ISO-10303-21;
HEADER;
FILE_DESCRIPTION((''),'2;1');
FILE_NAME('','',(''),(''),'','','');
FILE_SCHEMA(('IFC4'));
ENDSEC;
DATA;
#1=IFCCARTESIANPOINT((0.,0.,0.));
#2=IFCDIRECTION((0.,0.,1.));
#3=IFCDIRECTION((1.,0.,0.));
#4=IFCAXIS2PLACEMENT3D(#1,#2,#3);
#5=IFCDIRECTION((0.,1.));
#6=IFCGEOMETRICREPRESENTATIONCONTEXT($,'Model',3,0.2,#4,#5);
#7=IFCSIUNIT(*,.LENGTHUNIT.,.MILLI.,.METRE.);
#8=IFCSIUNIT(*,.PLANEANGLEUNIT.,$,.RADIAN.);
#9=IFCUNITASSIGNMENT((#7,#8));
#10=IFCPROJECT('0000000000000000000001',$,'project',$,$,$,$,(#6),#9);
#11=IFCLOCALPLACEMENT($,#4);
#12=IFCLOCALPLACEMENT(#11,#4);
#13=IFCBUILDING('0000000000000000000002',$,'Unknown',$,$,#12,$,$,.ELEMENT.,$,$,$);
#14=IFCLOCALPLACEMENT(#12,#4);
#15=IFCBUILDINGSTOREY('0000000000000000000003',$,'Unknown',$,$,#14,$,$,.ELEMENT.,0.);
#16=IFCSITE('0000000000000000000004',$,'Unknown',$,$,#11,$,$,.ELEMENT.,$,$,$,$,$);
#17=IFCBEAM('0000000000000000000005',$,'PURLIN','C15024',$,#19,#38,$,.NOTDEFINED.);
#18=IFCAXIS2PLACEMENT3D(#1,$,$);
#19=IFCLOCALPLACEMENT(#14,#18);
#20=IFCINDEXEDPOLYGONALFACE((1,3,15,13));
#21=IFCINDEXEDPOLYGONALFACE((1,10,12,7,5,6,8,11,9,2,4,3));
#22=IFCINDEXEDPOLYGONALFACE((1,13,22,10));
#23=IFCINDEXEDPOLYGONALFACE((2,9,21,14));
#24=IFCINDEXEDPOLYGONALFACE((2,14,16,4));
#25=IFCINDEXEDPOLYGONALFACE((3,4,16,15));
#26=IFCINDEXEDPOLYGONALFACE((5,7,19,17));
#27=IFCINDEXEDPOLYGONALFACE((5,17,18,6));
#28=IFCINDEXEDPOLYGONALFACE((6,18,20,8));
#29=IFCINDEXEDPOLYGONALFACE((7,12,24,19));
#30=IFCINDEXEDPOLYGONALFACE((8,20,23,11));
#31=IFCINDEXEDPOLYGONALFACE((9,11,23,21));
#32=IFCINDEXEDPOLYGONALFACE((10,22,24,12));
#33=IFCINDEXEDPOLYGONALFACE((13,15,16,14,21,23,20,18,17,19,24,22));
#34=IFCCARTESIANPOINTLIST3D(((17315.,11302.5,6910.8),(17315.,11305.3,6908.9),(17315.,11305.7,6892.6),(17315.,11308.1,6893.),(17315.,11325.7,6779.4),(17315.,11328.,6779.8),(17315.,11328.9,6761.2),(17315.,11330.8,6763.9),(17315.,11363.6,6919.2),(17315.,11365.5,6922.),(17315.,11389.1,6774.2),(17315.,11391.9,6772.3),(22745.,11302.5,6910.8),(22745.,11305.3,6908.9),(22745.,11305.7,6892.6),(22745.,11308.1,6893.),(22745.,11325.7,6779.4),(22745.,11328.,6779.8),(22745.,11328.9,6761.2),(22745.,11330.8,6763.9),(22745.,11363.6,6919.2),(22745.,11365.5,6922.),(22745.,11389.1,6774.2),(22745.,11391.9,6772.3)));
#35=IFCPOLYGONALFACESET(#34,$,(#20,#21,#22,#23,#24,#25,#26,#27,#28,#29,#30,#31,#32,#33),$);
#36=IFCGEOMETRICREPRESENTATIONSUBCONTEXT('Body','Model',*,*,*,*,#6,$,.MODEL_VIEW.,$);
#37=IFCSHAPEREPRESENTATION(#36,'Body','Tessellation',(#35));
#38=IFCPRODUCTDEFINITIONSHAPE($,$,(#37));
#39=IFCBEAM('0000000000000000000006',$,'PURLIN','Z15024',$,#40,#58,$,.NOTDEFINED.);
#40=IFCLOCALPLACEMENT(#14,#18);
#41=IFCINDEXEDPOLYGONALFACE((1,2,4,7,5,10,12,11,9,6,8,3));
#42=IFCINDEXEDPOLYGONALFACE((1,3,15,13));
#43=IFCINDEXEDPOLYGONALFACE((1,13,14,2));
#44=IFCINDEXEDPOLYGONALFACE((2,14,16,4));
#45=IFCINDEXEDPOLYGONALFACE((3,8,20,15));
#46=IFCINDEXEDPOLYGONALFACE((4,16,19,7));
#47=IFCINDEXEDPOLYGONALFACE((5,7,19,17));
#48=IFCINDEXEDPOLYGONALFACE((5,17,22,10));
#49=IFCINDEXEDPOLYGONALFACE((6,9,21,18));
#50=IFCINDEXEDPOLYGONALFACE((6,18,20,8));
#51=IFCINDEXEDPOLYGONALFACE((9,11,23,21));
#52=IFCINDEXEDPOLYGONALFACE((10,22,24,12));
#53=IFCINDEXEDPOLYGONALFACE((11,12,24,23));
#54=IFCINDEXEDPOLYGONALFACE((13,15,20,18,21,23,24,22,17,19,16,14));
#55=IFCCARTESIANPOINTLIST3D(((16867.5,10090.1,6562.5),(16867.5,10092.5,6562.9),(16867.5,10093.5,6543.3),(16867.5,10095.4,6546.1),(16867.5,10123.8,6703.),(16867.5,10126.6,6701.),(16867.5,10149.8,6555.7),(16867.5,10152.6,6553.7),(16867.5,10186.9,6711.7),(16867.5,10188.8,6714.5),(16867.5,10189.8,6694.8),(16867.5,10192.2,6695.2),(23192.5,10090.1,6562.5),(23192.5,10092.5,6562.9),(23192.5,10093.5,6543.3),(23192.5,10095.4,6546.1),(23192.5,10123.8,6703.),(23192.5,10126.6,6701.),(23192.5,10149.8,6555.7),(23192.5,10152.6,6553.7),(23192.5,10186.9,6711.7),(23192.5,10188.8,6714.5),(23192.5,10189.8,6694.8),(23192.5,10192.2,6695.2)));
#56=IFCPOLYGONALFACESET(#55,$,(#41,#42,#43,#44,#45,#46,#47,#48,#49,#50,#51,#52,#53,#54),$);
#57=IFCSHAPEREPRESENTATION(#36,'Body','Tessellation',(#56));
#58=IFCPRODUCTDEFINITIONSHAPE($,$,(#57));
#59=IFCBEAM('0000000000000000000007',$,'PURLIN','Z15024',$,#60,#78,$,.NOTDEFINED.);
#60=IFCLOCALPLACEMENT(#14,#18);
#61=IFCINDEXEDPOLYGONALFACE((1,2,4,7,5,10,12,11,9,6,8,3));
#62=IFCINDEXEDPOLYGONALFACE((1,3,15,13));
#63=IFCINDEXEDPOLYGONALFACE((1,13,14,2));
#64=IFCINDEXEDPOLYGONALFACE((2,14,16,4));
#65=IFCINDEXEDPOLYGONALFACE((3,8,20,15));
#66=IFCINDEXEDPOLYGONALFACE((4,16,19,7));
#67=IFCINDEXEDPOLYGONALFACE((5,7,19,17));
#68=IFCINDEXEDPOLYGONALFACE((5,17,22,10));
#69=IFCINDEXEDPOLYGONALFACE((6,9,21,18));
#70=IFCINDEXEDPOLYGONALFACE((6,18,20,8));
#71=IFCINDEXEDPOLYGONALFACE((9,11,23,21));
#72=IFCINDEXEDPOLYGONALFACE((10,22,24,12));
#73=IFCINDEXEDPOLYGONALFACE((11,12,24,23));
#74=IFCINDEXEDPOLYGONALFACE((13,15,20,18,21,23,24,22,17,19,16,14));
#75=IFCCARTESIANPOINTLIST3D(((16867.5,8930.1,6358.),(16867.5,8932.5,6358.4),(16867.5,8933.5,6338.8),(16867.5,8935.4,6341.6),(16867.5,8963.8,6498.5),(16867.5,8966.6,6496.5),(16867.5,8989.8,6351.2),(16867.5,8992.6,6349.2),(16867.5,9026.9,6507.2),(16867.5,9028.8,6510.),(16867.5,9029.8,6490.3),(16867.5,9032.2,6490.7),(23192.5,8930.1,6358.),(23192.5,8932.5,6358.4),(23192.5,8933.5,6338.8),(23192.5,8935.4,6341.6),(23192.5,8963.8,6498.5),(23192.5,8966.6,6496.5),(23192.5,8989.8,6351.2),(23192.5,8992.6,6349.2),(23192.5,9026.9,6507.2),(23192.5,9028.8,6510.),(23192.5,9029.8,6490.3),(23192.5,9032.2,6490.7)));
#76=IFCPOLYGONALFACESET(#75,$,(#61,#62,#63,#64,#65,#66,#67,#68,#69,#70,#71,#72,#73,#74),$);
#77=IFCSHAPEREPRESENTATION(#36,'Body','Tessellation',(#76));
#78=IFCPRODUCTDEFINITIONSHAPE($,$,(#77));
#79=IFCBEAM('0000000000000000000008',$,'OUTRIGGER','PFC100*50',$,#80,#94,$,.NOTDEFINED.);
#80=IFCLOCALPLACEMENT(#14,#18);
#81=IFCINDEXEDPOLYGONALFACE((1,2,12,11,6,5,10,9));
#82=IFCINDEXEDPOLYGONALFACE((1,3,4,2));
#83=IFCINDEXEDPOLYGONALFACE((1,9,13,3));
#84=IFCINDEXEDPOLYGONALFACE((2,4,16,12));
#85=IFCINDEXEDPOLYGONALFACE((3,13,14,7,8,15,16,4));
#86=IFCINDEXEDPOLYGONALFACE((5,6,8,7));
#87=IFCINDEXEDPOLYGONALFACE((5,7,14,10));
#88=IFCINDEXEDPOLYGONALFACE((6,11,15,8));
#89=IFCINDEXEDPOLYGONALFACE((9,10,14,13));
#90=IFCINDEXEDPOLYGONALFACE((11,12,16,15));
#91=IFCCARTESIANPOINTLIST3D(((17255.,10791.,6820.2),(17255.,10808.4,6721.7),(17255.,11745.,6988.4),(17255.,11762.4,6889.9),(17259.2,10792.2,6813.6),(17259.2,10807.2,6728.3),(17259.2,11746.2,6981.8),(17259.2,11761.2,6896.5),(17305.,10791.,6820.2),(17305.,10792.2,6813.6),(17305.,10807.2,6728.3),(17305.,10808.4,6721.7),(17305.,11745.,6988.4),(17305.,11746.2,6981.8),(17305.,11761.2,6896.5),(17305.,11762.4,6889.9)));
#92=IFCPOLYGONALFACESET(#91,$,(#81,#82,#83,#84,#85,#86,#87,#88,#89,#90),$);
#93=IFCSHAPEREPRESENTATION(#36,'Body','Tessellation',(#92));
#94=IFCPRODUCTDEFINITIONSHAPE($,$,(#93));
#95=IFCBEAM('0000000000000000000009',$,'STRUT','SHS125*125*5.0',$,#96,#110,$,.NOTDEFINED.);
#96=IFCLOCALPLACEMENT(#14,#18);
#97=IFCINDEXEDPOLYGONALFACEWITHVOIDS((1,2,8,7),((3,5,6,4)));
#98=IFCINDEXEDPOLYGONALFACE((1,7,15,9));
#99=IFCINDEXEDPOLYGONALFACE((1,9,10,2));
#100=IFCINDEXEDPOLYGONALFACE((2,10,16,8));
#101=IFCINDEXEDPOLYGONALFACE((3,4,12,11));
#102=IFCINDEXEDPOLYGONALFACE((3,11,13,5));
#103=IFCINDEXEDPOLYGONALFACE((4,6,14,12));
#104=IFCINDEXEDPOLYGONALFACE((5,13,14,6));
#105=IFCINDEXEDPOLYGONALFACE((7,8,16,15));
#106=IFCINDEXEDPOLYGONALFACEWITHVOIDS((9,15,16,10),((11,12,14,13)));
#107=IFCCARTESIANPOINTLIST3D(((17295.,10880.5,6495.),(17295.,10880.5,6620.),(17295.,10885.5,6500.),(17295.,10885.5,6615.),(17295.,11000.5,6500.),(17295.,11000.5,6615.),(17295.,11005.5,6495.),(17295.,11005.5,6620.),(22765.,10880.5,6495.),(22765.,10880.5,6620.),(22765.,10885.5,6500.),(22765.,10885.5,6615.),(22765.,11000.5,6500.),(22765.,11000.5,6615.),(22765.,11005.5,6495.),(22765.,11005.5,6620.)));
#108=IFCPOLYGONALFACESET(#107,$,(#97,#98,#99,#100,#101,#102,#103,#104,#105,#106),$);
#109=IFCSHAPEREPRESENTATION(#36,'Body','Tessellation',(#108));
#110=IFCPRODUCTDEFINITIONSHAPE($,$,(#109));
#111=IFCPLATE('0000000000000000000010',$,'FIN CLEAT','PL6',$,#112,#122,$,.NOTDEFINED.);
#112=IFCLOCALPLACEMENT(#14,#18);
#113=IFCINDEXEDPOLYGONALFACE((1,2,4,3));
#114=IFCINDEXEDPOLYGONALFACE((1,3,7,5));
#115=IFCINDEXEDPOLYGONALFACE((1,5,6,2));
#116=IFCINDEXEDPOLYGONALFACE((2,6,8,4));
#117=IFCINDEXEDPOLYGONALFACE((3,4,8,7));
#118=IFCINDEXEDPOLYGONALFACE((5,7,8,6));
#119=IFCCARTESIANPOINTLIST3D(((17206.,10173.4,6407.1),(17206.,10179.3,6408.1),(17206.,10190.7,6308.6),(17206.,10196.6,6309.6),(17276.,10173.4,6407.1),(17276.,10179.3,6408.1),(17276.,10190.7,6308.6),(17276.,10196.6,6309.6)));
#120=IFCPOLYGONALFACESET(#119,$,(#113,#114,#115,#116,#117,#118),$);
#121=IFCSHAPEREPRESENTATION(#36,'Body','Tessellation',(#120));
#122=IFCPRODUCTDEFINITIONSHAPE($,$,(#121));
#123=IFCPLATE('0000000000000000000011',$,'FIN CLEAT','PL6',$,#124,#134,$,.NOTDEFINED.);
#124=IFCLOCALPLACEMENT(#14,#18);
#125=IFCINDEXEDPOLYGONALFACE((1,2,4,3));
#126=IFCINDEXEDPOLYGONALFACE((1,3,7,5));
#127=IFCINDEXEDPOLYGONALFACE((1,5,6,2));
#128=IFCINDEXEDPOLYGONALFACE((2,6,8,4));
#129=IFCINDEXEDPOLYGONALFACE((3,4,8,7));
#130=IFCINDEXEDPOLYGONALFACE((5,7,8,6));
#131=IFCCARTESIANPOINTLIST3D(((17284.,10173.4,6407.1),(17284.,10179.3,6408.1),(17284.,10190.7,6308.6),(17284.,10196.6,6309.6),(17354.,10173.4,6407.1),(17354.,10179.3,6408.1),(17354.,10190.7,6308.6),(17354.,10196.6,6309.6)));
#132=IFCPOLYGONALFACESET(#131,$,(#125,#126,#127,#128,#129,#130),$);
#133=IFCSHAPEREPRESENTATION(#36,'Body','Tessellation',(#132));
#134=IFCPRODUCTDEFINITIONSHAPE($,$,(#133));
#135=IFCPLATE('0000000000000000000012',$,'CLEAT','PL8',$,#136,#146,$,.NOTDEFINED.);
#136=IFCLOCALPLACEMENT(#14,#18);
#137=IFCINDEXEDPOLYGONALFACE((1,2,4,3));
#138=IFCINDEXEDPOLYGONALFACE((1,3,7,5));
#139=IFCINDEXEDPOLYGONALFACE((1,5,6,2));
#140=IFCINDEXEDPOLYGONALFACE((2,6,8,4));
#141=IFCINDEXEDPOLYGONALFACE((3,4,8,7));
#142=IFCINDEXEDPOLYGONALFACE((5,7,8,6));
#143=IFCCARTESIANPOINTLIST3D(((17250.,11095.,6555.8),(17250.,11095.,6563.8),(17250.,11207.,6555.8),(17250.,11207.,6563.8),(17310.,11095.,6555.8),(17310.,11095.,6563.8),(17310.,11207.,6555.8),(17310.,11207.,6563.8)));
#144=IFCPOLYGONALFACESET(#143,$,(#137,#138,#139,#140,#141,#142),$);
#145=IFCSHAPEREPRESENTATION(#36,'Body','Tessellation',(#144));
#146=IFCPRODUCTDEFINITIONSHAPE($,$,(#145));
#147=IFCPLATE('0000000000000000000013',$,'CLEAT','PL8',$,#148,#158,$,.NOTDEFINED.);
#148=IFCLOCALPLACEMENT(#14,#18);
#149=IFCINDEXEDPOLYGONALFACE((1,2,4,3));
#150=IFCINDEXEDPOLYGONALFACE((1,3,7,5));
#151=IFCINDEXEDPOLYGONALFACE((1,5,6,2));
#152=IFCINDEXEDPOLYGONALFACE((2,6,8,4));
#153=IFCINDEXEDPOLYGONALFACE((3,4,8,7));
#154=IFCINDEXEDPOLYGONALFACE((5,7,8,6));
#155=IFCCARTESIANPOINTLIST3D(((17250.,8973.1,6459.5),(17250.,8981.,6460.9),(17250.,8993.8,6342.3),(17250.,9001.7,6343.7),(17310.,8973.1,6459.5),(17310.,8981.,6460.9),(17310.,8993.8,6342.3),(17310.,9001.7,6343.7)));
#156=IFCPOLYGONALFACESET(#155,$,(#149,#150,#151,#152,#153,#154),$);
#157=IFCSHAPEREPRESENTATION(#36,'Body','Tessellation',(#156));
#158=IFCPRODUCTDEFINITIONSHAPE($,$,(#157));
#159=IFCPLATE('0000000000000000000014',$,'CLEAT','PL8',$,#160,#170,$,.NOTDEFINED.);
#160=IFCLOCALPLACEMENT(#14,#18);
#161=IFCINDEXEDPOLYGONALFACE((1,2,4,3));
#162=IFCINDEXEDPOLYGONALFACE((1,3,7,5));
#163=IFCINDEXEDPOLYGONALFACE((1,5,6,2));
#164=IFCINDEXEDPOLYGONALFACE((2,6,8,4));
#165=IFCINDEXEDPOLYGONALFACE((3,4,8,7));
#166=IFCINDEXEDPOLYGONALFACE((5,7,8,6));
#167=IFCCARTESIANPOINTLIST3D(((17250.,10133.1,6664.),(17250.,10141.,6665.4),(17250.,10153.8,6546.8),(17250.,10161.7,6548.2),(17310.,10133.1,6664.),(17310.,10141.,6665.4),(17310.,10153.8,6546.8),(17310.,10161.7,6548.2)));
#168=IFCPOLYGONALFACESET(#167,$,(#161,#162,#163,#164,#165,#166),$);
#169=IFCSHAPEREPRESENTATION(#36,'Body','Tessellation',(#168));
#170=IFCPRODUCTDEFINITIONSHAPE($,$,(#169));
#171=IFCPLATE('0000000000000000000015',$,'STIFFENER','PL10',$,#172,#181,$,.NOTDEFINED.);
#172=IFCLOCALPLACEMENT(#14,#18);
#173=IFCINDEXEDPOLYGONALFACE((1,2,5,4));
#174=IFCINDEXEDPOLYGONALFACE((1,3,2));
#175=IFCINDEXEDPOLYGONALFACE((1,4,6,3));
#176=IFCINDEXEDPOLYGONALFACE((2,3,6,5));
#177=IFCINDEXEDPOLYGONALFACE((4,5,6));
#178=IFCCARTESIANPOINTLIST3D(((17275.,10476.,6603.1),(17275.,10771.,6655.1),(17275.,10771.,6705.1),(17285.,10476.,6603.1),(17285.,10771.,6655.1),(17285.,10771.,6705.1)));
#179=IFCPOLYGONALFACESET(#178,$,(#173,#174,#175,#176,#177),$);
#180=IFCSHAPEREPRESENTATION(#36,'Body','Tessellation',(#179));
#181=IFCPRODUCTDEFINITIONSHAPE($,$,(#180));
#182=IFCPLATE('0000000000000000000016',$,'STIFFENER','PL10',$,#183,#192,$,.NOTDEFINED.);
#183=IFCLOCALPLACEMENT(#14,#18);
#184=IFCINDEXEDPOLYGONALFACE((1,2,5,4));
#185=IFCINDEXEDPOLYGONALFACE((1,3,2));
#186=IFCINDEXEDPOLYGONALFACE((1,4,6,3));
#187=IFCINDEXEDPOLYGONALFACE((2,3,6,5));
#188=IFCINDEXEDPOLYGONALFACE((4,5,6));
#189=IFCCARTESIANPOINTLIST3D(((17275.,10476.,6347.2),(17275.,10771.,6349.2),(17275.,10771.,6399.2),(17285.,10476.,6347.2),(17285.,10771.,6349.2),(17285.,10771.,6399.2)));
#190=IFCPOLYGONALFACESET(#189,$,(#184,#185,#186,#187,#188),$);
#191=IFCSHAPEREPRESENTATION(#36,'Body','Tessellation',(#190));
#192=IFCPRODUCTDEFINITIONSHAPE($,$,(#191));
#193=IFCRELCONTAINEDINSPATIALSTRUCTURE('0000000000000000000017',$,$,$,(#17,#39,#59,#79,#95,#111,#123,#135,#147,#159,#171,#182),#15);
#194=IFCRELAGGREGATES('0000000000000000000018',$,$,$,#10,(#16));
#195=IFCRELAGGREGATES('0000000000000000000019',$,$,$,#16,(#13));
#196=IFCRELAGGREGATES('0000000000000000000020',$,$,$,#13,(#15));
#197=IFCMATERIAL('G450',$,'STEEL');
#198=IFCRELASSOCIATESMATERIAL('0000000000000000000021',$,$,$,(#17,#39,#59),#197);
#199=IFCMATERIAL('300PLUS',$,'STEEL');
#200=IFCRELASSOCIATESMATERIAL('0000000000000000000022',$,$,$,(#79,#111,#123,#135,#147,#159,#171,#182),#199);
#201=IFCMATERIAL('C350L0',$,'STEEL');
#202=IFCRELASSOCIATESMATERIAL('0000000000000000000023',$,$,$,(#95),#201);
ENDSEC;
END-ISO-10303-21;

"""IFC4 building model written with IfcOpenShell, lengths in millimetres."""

from ifc_helpers import new_model, si_unit, direction, frame, origin_with_axes, place, context, subcontext, project, spatial, line, indexed_curve, outline, extrude, material, element, save


model = new_model("IFC4")

# Units and contexts
model_context = context("Model", 3, precision=0.2, world=origin_with_axes(), true_north=direction((0.0, 1.0)))
body_context = subcontext(model_context, "Body", "Model", "MODEL_VIEW")
ifc_project = project(units=[si_unit("LENGTHUNIT", "METRE", prefix="MILLI"), si_unit("PLANEANGLEUNIT", "RADIAN")], contexts=[model_context])

# Site, building, storey
site_placement = place(None, origin_with_axes())
site = spatial("IfcSite", under=ifc_project, at=site_placement, Name="Unknown", CompositionType="ELEMENT")
building_placement = place(site_placement, origin_with_axes())
building = spatial("IfcBuilding", under=site, at=building_placement, Name="Unknown", CompositionType="ELEMENT")
storey_placement = place(building_placement, origin_with_axes())
storey = spatial("IfcBuildingStorey", under=building, at=storey_placement, Name="Unknown", CompositionType="ELEMENT", Elevation=0.0)

# Shared definitions
ifc_material_1 = material(Name="300PLUS", Category="STEEL")

# Beams
ifc_material_2 = material(Name="G450", Category="STEEL")
beam_1_placement = place(storey_placement, frame((17315.0, 11347.2, 6841.6), z_axis=(0.0, -0.984808, -0.173648), x_axis=(1.0, 0.0, 0.0)))
element("IfcBeam", 1, at=beam_1_placement, inside=storey, material=ifc_material_2, Name="PURLIN", Description="C15024", PredefinedType="NOTDEFINED", context=body_context, shape_type="SolidModel", body=[
    extrude(outline(indexed_curve([(32.0, -76.0), (32.0, -57.5), (29.6, -57.5), (29.6, -73.6), (-29.6, -73.6), (-29.6, 73.6), (29.6, 73.6), (29.6, 57.5), (32.0, 57.5), (32.0, 76.0), (-32.0, 76.0), (-32.0, -76.0)], segments=[line(1, 2, 3, 4, 5, 6, 7, 8, 9, 10, 11, 12, 1)])), frame((0.0, 0.0, 0.0), z_axis=(-1.0, 0.0, 0.0), x_axis=(0.0, 0.0, 1.0)), (0.0, 0.0, -1.0), 5430.0),
])
for number, where, z_axis, x_axis, name in (
    (2, (16867.5, 10138.2, 6628.4), (0.0, -0.984808, -0.173648), (1.0, 0.0, 0.0), "PURLIN"),
    (3, (16867.5, 8978.2, 6423.9), (0.0, -0.984808, -0.173648), (1.0, 0.0, 0.0), "PURLIN"),
):
    element("IfcBeam", number, at=place(storey_placement, frame(where, z_axis=z_axis, x_axis=x_axis)), inside=storey, material=ifc_material_2, Name=name, Description="Z15024", PredefinedType="NOTDEFINED", context=body_context, shape_type="SolidModel", body=[
        extrude(outline(indexed_curve([(58.8, -76.0), (58.8, -56.5), (56.4, -56.5), (56.4, -73.6), (1.2, -73.6), (1.2, 76.0), (-64.8, 76.0), (-64.8, 56.5), (-62.4, 56.5), (-62.4, 73.6), (-1.2, 73.6), (-1.2, -76.0)], segments=[line(1, 2, 3, 4, 5, 6, 7, 8, 9, 10, 11, 12, 1)])), frame((0.0, 0.0, 0.0), z_axis=(-1.0, 0.0, 0.0), x_axis=(0.0, 0.0, 1.0)), (0.0, 0.0, -1.0), 6325.0),
    ])
beam_2_placement = place(storey_placement, frame((17280.0, 10799.7, 6771.0), z_axis=(1.0, 0.0, 0.0), x_axis=(0.0, 0.984811, 0.173632)))
element("IfcBeam", 4, at=beam_2_placement, inside=storey, material=ifc_material_1, Name="OUTRIGGER", Description="PFC100*50", PredefinedType="NOTDEFINED", context=body_context, shape_type="SolidModel", body=[
    extrude(outline(indexed_curve([(-25.0, -50.0), (25.0, -50.0), (25.0, -43.3), (-20.8, -43.3), (-20.8, 43.3), (25.0, 43.3), (25.0, 50.0), (-25.0, 50.0)], segments=[line(1, 2, 3, 4, 5, 6, 7, 8, 1)])), frame((0.0, 0.0, 0.0), z_axis=(-1.0, 0.0, 0.0), x_axis=(0.0, 0.0, 1.0)), (0.0, 0.0, -1.0), 968.7),
])
ifc_material_3 = material(Name="C350L0", Category="STEEL")
beam_3_placement = place(storey_placement, frame((17295.0, 10943.0, 6557.5), z_axis=(0.0, 0.0, 1.0), x_axis=(1.0, 0.0, 0.0)))
element("IfcBeam", 5, at=beam_3_placement, inside=storey, material=ifc_material_3, Name="STRUT", Description="SHS125*125*5.0", PredefinedType="NOTDEFINED", context=body_context, shape_type="SolidModel", body=[
    extrude(outline(indexed_curve([(-62.5, -62.5), (62.5, -62.5), (62.5, 62.5), (-62.5, 62.5)], segments=[line(1, 2, 3, 4, 1)]), holes=[indexed_curve([(-57.5, -57.5), (-57.5, 57.5), (57.5, 57.5), (57.5, -57.5)], segments=[line(1, 2, 3, 4, 1)])]), frame((0.0, 0.0, 0.0), z_axis=(-1.0, 0.0, 0.0), x_axis=(0.0, 0.0, 1.0)), (0.0, 0.0, -1.0), 5470.0),
])

# Plates
for number, where, z_axis, x_axis, name in (
    (6, (17206.0, 10176.4, 6407.6), (0.0, 0.984924, 0.172987), (1.0, 0.0, 0.0), "FIN CLEAT"),
    (7, (17284.0, 10176.4, 6407.6), (0.0, 0.984924, 0.172987), (1.0, 0.0, 0.0), "FIN CLEAT"),
):
    element("IfcPlate", number, at=place(storey_placement, frame(where, z_axis=z_axis, x_axis=x_axis)), inside=storey, material=ifc_material_1, Name=name, Description="PL6", PredefinedType="NOTDEFINED", context=body_context, shape_type="SolidModel", body=[
        extrude(outline(indexed_curve([(0.0, 0.0), (70.0, 0.0), (70.0, 100.0), (0.0, 100.0)], segments=[line(1, 2, 3, 4, 1)])), frame((0.0, 0.0, 3.0), z_axis=(0.0, 0.0, 1.0), x_axis=(1.0, 0.0, 0.0)), (0.0, 0.0, -1.0), 6.0),
    ])
plate_1_placement = place(storey_placement, frame((17250.0, 11095.0, 6559.8), z_axis=(0.0, 0.0, 1.0), x_axis=(1.0, 0.0, 0.0)))
element("IfcPlate", 8, at=plate_1_placement, inside=storey, material=ifc_material_1, Name="CLEAT", Description="PL8", PredefinedType="NOTDEFINED", context=body_context, shape_type="SolidModel", body=[
    extrude(outline(indexed_curve([(0.0, 0.0), (60.0, 0.0), (60.0, 112.0), (0.0, 112.0)], segments=[line(1, 2, 3, 4, 1)])), frame((0.0, 0.0, 4.0), z_axis=(0.0, 0.0, 1.0), x_axis=(1.0, 0.0, 0.0)), (0.0, 0.0, -1.0), 8.0),
])
for number, where, z_axis, x_axis, name in (
    (9, (17310.0, 8997.7, 6343.0), (0.0, 0.984758, 0.173929), (-1.0, 0.0, 0.0), "CLEAT"),
    (10, (17310.0, 10157.7, 6547.5), (0.0, 0.984758, 0.173929), (-1.0, 0.0, 0.0), "CLEAT"),
):
    element("IfcPlate", number, at=place(storey_placement, frame(where, z_axis=z_axis, x_axis=x_axis)), inside=storey, material=ifc_material_1, Name=name, Description="PL8", PredefinedType="NOTDEFINED", context=body_context, shape_type="SolidModel", body=[
        extrude(outline(indexed_curve([(0.0, 0.0), (60.0, 0.0), (60.0, 119.0), (0.0, 119.0)], segments=[line(1, 2, 3, 4, 1)])), frame((0.0, 0.0, 4.0), z_axis=(0.0, 0.0, 1.0), x_axis=(1.0, 0.0, 0.0)), (0.0, 0.0, -1.0), 8.0),
    ])
plate_2_placement = place(storey_placement, frame((17280.0, 10771.0, 6655.1), z_axis=(1.0, 0.0, 0.0), x_axis=(0.0, 0.0, 1.0)))
element("IfcPlate", 11, at=plate_2_placement, inside=storey, material=ifc_material_1, Name="STIFFENER", Description="PL10", PredefinedType="NOTDEFINED", context=body_context, shape_type="SolidModel", body=[
    extrude(outline(indexed_curve([(0.0, 0.0), (50.0, 0.0), (-52.0, 295.0)], segments=[line(1, 2, 3, 1)])), frame((0.0, 0.0, 5.0), z_axis=(0.0, 0.0, 1.0), x_axis=(1.0, 0.0, 0.0)), (0.0, 0.0, -1.0), 10.0),
])
plate_3_placement = place(storey_placement, frame((17280.0, 10771.0, 6349.2), z_axis=(1.0, 0.0, 0.0), x_axis=(0.0, 0.0, 1.0)))
element("IfcPlate", 12, at=plate_3_placement, inside=storey, material=ifc_material_1, Name="STIFFENER", Description="PL10", PredefinedType="NOTDEFINED", context=body_context, shape_type="SolidModel", body=[
    extrude(outline(indexed_curve([(0.0, 0.0), (50.0, 0.0), (-2.0, 295.0)], segments=[line(1, 2, 3, 1)])), frame((0.0, 0.0, 5.0), z_axis=(0.0, 0.0, 1.0), x_axis=(1.0, 0.0, 0.0)), (0.0, 0.0, -1.0), 10.0),
])

save(model, "model.ifc")
